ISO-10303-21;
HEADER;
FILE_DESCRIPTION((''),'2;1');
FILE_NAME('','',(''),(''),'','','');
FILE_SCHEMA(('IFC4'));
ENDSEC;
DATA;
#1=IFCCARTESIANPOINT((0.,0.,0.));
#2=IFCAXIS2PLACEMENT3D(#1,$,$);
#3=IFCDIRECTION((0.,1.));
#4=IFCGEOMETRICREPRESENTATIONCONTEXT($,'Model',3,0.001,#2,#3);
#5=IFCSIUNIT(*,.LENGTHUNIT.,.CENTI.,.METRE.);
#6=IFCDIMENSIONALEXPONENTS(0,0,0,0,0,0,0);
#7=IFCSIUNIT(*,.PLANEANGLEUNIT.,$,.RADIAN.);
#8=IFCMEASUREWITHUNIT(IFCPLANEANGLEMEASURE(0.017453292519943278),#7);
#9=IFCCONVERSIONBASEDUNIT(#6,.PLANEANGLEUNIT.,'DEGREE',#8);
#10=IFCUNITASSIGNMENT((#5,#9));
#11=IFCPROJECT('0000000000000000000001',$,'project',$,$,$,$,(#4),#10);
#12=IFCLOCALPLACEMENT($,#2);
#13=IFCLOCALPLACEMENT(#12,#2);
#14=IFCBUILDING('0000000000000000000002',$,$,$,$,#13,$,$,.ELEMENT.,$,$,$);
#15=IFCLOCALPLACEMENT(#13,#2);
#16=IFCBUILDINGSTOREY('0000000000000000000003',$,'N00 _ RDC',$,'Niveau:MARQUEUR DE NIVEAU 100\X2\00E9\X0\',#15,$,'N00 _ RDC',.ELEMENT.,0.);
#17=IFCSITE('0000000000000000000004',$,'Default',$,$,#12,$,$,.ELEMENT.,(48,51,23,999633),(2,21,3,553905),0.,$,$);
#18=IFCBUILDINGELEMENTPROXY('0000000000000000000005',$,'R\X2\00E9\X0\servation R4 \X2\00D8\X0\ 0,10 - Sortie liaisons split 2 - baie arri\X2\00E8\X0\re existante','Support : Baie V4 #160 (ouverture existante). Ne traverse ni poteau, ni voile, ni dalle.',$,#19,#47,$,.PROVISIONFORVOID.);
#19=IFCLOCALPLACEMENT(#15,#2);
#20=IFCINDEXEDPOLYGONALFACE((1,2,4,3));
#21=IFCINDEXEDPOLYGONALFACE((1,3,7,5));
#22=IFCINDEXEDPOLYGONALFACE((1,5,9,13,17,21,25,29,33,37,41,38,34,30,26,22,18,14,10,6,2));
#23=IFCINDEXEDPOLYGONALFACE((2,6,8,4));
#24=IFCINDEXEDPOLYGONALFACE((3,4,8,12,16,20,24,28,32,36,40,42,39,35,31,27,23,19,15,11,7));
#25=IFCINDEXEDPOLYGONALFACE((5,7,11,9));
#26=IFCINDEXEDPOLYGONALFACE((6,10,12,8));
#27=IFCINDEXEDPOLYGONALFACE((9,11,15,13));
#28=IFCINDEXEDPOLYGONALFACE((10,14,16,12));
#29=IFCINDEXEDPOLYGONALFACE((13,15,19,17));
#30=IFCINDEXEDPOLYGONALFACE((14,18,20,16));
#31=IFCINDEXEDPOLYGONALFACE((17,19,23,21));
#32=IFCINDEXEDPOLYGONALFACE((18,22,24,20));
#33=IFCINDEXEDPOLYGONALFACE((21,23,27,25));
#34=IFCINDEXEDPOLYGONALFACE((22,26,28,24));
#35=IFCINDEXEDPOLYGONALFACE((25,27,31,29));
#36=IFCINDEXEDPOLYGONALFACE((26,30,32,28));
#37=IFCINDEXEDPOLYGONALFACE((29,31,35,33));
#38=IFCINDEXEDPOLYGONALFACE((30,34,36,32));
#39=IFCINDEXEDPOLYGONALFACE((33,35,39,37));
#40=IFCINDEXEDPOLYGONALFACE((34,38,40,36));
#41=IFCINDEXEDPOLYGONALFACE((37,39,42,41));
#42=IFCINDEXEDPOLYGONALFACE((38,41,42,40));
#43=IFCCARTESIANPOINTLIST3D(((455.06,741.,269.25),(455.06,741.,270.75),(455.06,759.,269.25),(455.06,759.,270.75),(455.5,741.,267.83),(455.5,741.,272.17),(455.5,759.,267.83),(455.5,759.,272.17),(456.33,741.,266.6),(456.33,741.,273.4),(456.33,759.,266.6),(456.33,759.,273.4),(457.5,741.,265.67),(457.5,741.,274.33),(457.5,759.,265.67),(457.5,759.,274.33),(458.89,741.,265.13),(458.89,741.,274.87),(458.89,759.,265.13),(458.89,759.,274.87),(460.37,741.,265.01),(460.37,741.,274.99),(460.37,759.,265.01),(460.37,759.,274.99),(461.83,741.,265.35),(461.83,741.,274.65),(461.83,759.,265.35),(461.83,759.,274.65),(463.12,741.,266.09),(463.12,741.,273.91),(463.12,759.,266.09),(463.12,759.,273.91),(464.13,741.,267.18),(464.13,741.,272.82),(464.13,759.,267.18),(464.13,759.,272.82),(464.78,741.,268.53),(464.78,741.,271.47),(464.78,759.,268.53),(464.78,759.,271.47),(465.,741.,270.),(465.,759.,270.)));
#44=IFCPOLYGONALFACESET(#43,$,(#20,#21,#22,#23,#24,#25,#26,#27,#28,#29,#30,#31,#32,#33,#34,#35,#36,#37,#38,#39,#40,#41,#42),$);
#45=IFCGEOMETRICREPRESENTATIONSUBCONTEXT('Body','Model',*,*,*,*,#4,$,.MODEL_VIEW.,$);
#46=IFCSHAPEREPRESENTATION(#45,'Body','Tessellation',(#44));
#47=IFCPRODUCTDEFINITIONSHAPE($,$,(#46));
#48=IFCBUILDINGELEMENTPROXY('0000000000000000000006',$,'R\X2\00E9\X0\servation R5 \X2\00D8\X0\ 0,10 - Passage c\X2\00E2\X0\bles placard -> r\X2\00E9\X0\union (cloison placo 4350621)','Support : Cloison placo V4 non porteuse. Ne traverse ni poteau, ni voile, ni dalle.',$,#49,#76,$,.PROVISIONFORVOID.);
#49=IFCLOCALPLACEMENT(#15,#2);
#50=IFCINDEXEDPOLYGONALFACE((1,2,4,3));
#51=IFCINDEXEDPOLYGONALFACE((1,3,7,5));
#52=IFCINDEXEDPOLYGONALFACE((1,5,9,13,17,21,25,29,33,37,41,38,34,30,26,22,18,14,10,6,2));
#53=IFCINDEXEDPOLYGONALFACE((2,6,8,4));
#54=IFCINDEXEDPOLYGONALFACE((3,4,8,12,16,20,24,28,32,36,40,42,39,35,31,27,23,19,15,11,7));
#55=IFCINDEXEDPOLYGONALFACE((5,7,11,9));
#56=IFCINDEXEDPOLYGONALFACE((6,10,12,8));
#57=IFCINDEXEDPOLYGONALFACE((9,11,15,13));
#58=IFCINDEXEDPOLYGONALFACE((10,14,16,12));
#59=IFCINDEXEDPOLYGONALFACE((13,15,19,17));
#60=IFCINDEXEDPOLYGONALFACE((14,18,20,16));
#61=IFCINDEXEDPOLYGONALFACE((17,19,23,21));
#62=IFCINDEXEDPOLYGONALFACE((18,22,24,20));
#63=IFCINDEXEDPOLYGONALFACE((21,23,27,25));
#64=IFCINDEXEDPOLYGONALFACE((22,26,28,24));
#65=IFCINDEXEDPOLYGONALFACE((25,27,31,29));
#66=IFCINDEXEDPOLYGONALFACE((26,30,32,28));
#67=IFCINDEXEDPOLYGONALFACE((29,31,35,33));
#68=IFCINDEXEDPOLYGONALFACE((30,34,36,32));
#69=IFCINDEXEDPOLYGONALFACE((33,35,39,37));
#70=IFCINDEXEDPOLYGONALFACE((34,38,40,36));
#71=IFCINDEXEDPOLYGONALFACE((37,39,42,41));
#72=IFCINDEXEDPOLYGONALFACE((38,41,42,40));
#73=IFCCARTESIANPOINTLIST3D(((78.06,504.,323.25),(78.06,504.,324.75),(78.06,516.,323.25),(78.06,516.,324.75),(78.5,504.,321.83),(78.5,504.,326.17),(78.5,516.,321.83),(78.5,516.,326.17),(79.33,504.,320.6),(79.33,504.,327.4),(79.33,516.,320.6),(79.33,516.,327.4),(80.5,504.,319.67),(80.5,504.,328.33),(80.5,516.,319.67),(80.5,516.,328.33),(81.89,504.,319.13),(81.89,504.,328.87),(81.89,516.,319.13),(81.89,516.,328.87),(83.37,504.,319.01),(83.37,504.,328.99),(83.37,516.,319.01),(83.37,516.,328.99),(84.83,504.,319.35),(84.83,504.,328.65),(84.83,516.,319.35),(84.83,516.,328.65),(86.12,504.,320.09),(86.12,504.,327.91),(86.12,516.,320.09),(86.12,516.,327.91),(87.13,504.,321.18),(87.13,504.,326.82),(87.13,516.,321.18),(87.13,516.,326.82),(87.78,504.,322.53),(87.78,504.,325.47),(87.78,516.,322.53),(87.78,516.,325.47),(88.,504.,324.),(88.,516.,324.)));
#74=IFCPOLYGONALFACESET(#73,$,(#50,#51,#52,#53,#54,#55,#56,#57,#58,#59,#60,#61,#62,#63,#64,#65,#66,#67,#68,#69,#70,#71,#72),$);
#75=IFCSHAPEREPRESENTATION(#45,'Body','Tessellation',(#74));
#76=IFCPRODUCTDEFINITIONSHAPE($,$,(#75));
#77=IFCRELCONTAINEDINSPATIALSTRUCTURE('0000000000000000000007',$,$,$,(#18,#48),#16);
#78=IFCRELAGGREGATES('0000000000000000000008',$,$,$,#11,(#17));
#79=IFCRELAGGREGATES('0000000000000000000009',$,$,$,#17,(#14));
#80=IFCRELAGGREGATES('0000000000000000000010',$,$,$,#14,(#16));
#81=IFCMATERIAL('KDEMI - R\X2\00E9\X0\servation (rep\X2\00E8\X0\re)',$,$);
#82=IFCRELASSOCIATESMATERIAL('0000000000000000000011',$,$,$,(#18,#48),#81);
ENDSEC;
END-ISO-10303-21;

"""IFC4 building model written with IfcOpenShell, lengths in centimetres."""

from ifc_helpers import new_model, entity, si_unit, converted_unit, direction, frame, origin, origin_with_axes, origin_2d, place, context, subcontext, project, spatial, circle, extrude, material, element, save


model = new_model("IFC4")

# Units and contexts
model_context = context("Model", 3, precision=0.001, world=origin(), true_north=direction((0.0, 1.0)))
body_context = subcontext(model_context, "Body", "Model", "MODEL_VIEW")
ifc_project = project(units=[si_unit("LENGTHUNIT", "METRE", prefix="CENTI"), converted_unit("PLANEANGLEUNIT", "DEGREE", entity("IfcPlaneAngleMeasure", 0.017453292519943278), si_unit("PLANEANGLEUNIT", "RADIAN"), dimensions=[0, 0, 0, 0, 0, 0, 0])], contexts=[model_context])

# Site, building, storey
site_placement = place(None, origin())
site = spatial("IfcSite", under=ifc_project, at=site_placement, Name="Default", CompositionType="ELEMENT", RefLatitude=(48, 51, 23, 999633), RefLongitude=(2, 21, 3, 553905), RefElevation=0.0)
building_placement = place(site_placement, origin())
building = spatial("IfcBuilding", under=site, at=building_placement, CompositionType="ELEMENT")
storey_placement = place(building_placement, origin())
storey = spatial("IfcBuildingStorey", under=building, at=storey_placement, Name="N00 _ RDC", ObjectType="Niveau:MARQUEUR DE NIVEAU 100é", LongName="N00 _ RDC", CompositionType="ELEMENT", Elevation=0.0)

# Building element proxies
ifc_material_1 = material(Name="KDEMI - Réservation (repère)")
proxy_1_placement = place(storey_placement, origin_with_axes())
element("IfcBuildingElementProxy", 1, at=proxy_1_placement, inside=storey, material=ifc_material_1, Name="Réservation R4 Ø 0,10 - Sortie liaisons split 2 - baie arrière existante", Description="Support : Baie V4 #160 (ouverture existante). Ne traverse ni poteau, ni voile, ni dalle.", PredefinedType="PROVISIONFORVOID", context=body_context, shape_type="SweptSolid", body=[
    extrude(circle(Radius=5.0, at=origin_2d()), frame((460.0, 741.0, 270.0), z_axis=(0.0, 1.0, 0.0), x_axis=(1.0, 0.0, 0.0)), (0.0, 0.0, 1.0), 18.0),
])
proxy_2_placement = place(storey_placement, origin_with_axes())
element("IfcBuildingElementProxy", 2, at=proxy_2_placement, inside=storey, material=ifc_material_1, Name="Réservation R5 Ø 0,10 - Passage câbles placard -> réunion (cloison placo 4350621)", Description="Support : Cloison placo V4 non porteuse. Ne traverse ni poteau, ni voile, ni dalle.", PredefinedType="PROVISIONFORVOID", context=body_context, shape_type="SweptSolid", body=[
    extrude(circle(Radius=5.0, at=origin_2d()), frame((83.0, 504.0, 324.0), z_axis=(0.0, 1.0, 0.0), x_axis=(1.0, 0.0, 0.0)), (0.0, 0.0, 1.0), 12.0),
])

save(model, "model.ifc")
